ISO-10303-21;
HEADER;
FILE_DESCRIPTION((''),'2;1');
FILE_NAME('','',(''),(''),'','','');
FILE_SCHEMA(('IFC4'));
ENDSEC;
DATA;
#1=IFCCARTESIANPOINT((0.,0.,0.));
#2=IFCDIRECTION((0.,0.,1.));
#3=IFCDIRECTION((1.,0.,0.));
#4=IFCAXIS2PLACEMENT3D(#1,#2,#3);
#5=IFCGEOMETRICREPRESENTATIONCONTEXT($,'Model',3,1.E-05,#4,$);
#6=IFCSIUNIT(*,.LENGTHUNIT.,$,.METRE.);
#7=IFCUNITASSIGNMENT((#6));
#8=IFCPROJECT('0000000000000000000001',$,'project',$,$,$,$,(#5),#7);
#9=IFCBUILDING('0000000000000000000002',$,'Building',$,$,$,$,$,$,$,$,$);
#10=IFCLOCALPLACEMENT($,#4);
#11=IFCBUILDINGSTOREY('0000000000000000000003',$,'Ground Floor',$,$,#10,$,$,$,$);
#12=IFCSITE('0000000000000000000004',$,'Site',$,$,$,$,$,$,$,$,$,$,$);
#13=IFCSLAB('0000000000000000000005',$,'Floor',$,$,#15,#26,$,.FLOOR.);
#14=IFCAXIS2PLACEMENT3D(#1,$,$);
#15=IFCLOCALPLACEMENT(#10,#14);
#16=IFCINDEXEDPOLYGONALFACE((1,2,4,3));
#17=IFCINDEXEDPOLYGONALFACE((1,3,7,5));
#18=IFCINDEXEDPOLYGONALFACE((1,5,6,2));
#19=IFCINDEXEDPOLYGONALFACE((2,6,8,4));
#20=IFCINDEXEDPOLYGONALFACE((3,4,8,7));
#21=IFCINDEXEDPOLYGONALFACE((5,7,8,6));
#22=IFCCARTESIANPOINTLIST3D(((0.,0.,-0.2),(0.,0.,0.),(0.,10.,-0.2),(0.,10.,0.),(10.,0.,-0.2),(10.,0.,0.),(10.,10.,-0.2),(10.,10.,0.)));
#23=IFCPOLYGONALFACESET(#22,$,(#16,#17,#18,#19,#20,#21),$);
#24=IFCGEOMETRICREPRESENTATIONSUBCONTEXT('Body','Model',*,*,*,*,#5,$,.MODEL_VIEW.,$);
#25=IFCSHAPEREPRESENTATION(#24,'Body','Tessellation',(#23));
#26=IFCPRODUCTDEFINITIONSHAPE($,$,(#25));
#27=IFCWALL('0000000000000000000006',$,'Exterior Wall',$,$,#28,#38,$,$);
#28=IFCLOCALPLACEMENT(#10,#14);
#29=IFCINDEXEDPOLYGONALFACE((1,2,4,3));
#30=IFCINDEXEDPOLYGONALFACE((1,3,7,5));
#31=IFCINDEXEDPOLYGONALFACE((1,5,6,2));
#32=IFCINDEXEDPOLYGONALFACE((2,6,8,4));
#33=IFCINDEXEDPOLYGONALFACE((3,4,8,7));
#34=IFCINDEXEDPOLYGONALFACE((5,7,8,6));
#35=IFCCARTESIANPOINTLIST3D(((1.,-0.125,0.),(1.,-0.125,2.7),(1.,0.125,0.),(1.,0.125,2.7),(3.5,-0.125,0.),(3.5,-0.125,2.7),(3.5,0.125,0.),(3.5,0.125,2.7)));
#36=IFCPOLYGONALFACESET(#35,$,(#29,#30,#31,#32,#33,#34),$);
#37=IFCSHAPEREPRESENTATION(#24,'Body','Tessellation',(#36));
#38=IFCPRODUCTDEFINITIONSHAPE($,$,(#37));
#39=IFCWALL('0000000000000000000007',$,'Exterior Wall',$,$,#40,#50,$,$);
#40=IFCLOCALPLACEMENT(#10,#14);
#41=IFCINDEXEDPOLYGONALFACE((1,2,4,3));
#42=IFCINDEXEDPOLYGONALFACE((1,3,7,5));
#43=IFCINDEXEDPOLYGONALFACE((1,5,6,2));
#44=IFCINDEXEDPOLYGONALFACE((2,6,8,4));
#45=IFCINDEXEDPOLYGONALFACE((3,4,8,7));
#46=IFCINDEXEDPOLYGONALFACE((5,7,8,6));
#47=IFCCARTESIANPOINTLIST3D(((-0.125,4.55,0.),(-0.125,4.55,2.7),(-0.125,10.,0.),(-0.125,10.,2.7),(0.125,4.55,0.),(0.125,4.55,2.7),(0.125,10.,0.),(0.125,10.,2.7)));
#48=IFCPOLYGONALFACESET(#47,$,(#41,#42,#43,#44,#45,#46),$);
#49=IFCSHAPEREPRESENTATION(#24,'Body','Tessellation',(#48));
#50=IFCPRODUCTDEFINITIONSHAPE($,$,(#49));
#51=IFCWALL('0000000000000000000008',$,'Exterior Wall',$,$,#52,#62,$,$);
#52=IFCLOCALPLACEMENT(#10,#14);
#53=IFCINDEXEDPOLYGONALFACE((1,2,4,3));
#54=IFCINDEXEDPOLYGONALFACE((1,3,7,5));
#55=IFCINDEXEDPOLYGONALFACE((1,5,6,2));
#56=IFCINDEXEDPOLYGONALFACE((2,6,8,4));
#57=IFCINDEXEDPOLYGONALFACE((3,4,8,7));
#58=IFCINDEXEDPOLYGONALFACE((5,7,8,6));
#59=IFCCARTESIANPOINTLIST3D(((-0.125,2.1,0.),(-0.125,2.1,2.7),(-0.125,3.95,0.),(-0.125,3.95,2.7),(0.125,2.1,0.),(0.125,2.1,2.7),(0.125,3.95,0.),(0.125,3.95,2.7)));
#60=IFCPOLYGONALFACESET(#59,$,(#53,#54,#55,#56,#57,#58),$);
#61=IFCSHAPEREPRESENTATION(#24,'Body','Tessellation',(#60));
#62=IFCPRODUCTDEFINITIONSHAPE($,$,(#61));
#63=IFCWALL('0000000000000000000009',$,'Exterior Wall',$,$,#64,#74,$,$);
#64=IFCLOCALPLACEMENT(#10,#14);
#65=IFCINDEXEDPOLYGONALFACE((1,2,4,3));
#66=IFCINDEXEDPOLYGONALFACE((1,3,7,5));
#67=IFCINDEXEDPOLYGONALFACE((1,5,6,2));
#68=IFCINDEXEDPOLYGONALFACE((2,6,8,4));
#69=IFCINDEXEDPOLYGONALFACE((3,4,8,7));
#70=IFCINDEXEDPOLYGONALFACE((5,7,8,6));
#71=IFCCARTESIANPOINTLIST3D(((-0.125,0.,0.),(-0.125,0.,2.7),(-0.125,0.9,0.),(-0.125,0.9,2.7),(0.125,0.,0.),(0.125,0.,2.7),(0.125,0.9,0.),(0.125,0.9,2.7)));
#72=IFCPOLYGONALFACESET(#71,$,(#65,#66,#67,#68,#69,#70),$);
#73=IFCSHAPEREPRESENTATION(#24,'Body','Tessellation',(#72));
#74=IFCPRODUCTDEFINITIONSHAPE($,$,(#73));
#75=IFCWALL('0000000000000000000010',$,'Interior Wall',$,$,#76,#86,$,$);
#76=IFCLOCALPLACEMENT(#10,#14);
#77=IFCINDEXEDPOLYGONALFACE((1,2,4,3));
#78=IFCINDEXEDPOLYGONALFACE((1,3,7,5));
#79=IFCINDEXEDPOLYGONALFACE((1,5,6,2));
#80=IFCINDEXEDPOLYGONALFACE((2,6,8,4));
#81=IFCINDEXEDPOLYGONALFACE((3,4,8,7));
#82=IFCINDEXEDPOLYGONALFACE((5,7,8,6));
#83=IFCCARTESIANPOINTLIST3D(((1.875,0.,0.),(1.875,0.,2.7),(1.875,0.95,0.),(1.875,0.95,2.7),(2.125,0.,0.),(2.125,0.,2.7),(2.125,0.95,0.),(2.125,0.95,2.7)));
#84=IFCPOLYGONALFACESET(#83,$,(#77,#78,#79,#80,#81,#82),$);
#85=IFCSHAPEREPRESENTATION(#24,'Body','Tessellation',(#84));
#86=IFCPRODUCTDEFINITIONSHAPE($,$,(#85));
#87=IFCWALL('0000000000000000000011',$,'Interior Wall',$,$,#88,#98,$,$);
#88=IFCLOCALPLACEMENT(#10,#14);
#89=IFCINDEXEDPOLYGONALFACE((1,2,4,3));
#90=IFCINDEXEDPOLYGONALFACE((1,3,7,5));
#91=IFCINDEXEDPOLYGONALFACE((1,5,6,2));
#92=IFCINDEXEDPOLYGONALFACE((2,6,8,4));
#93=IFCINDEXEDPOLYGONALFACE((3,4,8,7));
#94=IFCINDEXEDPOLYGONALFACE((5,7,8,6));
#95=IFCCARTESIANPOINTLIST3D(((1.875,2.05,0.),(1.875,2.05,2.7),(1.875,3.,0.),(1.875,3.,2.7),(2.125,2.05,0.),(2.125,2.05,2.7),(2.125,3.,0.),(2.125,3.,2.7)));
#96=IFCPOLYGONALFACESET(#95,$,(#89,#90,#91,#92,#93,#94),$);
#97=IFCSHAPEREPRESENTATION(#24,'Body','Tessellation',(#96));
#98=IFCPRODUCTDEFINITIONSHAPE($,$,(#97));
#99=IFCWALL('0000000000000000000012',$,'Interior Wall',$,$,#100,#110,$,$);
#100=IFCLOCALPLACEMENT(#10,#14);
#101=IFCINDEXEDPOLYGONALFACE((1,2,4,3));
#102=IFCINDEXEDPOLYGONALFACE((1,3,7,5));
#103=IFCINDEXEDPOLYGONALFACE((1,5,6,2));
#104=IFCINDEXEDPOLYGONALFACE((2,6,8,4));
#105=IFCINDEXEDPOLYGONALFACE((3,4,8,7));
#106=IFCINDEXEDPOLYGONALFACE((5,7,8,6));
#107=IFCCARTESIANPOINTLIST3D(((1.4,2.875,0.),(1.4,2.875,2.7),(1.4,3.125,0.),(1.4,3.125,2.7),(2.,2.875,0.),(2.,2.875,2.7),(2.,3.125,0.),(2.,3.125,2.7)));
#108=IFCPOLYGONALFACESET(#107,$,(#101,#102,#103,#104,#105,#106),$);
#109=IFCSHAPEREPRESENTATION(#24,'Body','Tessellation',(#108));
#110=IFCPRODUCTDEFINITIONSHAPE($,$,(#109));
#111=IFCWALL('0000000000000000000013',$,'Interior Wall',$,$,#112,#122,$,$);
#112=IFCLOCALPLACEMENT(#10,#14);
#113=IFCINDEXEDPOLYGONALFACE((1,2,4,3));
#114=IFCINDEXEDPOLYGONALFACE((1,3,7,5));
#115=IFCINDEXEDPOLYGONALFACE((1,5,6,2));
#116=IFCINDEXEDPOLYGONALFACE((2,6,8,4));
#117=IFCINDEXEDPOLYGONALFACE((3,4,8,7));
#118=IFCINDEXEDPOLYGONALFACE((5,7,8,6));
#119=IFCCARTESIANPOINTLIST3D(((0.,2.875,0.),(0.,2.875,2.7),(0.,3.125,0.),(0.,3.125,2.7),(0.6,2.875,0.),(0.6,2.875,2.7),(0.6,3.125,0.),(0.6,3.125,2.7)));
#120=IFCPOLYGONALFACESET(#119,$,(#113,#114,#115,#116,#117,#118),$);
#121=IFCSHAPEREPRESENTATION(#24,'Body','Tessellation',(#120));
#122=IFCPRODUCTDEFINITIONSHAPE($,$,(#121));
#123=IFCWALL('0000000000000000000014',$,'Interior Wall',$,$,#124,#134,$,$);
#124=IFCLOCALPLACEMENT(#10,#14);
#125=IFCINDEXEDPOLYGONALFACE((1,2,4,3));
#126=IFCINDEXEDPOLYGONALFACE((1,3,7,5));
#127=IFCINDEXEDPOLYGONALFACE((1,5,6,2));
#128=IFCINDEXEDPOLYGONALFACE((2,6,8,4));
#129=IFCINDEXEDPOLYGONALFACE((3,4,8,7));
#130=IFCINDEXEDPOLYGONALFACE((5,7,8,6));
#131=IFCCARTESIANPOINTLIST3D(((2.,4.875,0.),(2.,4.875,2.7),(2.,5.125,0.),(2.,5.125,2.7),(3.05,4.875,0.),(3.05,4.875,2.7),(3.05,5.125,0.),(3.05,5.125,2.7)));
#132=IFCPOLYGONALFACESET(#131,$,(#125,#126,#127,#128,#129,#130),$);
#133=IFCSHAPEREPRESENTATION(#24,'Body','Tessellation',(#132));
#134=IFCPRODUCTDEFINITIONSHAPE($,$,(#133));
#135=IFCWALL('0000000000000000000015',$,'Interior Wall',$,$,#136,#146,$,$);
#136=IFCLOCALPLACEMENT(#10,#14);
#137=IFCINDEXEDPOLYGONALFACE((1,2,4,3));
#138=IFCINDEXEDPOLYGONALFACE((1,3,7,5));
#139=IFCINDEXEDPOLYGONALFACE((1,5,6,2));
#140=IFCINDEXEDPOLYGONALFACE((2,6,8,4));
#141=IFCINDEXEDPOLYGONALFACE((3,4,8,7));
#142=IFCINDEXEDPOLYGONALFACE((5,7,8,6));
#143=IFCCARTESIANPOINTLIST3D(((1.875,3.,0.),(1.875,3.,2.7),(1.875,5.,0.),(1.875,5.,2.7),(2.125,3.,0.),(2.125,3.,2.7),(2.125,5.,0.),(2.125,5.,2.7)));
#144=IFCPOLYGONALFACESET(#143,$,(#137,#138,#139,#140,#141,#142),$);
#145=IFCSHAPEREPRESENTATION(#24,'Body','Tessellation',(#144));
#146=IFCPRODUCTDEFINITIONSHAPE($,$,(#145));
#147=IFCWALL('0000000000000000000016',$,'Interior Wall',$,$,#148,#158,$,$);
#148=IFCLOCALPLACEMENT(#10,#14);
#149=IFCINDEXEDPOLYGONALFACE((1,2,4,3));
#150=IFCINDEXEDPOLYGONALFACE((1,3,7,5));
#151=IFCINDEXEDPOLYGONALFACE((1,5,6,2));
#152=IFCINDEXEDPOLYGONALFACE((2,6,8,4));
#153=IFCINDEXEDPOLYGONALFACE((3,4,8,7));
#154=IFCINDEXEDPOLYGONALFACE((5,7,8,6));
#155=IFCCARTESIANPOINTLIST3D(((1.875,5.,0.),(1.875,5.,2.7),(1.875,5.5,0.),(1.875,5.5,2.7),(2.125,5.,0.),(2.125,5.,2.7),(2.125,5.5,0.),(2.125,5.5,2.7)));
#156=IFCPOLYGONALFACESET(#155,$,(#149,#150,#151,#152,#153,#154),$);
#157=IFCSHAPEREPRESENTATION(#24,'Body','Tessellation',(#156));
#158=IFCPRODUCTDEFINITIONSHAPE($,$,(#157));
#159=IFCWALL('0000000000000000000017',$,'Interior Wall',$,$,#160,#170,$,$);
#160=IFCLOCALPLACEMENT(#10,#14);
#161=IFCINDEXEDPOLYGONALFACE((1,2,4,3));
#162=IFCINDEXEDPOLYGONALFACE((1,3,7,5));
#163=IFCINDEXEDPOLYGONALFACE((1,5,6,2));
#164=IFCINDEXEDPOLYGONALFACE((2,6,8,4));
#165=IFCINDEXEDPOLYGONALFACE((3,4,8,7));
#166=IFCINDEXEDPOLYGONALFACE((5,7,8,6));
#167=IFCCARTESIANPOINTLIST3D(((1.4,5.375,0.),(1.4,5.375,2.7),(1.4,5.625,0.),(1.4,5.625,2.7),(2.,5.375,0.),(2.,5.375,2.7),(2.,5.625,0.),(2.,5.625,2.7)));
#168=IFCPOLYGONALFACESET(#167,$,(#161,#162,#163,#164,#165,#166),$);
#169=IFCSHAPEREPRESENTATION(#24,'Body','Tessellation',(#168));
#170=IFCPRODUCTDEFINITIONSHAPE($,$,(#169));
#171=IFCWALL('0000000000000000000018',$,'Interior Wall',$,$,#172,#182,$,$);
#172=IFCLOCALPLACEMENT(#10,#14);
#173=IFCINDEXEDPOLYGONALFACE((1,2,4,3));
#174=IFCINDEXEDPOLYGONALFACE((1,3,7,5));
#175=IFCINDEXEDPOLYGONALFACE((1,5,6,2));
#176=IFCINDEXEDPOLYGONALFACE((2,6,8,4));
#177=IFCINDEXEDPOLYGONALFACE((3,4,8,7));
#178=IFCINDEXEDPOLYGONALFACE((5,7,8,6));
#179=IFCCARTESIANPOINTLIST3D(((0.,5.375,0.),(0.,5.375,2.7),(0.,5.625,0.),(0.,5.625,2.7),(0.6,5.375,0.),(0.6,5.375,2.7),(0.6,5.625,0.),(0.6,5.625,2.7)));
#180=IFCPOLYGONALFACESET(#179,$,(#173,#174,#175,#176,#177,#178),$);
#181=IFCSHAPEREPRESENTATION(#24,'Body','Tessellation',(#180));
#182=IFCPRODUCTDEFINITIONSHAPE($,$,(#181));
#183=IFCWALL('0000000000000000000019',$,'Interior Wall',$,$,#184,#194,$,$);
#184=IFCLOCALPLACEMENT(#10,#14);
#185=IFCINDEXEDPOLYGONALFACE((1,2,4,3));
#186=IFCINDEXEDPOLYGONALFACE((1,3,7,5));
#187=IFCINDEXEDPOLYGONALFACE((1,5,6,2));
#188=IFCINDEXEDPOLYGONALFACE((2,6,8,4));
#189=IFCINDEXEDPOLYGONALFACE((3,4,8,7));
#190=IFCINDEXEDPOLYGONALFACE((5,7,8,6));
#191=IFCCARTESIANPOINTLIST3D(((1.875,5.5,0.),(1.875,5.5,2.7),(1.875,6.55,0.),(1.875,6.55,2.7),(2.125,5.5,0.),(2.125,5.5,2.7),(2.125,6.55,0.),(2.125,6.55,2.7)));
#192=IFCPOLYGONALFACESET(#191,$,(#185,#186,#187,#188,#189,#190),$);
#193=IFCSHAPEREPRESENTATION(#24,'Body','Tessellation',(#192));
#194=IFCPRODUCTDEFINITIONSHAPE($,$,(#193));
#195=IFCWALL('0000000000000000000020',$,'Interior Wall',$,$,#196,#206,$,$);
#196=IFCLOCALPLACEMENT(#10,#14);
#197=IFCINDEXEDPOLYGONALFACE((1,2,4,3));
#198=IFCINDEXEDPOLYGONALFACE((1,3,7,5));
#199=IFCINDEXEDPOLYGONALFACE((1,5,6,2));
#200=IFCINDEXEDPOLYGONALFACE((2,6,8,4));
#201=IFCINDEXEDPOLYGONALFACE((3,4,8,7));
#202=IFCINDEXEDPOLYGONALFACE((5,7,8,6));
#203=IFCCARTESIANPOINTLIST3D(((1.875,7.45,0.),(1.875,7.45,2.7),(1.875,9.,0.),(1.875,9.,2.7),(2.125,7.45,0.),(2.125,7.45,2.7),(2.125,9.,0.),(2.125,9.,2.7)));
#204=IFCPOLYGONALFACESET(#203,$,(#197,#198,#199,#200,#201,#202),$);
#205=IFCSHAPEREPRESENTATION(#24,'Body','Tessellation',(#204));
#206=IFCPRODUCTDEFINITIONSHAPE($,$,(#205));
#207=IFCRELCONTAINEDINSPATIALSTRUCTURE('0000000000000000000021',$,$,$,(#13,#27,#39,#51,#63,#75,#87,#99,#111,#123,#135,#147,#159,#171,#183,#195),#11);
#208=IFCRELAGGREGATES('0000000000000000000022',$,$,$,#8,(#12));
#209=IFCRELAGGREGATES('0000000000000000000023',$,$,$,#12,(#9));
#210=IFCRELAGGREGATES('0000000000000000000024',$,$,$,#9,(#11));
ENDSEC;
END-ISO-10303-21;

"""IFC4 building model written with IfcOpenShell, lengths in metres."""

from ifc_helpers import new_model, si_unit, frame, origin_with_axes, place, context, subcontext, project, spatial, indexed_curve, outline, extrude, element, save


model = new_model("IFC4")

# Units and contexts
model_context = context("Model", 3, precision=1e-05, world=origin_with_axes())
body_context = subcontext(model_context, "Body", "Model", "MODEL_VIEW")
ifc_project = project(units=[si_unit("LENGTHUNIT", "METRE")], contexts=[model_context])

# Site, building, storey
site = spatial("IfcSite", under=ifc_project, Name="Site")
building = spatial("IfcBuilding", under=site, Name="Building")
storey_placement = place(None, origin_with_axes())
storey = spatial("IfcBuildingStorey", under=building, at=storey_placement, Name="Ground Floor")

# Slab
slab_placement = place(storey_placement, frame((0.0, 0.0, -0.2), z_axis=(0.0, 0.0, 1.0), x_axis=(1.0, 0.0, 0.0)))
element("IfcSlab", 1, at=slab_placement, inside=storey, Name="Floor", PredefinedType="FLOOR", context=body_context, shape_type="SweptSolid", body=[
    extrude(outline(indexed_curve([(0.0, 0.0), (10.0, 0.0), (10.0, 10.0), (0.0, 10.0)])), None, (0.0, 0.0, 1.0), 0.2),
])

# Walls
wall_1_placement = place(storey_placement, frame((1.0, 0.0, 0.0), z_axis=(0.0, 0.0, 1.0), x_axis=(1.0, 0.0, 0.0)))
element("IfcWall", 2, at=wall_1_placement, inside=storey, Name="Exterior Wall", context=body_context, shape_type="SweptSolid", body=[
    extrude(outline(indexed_curve([(0.0, 0.0), (0.0, 0.25), (2.5, 0.25), (2.5, 0.0), (0.0, 0.0)], self_intersect=False)), frame((0.0, -0.125, 0.0), z_axis=(0.0, 0.0, 1.0), x_axis=(1.0, 0.0, 0.0)), (0.0, 0.0, 1.0), 2.7),
])
wall_2_placement = place(storey_placement, frame((0.0, 10.0, 0.0), z_axis=(0.0, 0.0, 1.0), x_axis=(0.0, -1.0, 0.0)))
element("IfcWall", 3, at=wall_2_placement, inside=storey, Name="Exterior Wall", context=body_context, shape_type="SweptSolid", body=[
    extrude(outline(indexed_curve([(0.0, 0.0), (0.0, 0.25), (5.45, 0.25), (5.45, 0.0), (0.0, 0.0)], self_intersect=False)), frame((0.0, -0.125, 0.0), z_axis=(0.0, 0.0, 1.0), x_axis=(1.0, 0.0, 0.0)), (0.0, 0.0, 1.0), 2.7),
])
wall_3_placement = place(storey_placement, frame((0.0, 3.95, 0.0), z_axis=(0.0, 0.0, 1.0), x_axis=(0.0, -1.0, 0.0)))
element("IfcWall", 4, at=wall_3_placement, inside=storey, Name="Exterior Wall", context=body_context, shape_type="SweptSolid", body=[
    extrude(outline(indexed_curve([(0.0, 0.0), (0.0, 0.25), (1.85, 0.25), (1.85, 0.0), (0.0, 0.0)], self_intersect=False)), frame((0.0, -0.125, 0.0), z_axis=(0.0, 0.0, 1.0), x_axis=(1.0, 0.0, 0.0)), (0.0, 0.0, 1.0), 2.7),
])
wall_4_placement = place(storey_placement, frame((0.0, 0.9, 0.0), z_axis=(0.0, 0.0, 1.0), x_axis=(0.0, -1.0, 0.0)))
element("IfcWall", 5, at=wall_4_placement, inside=storey, Name="Exterior Wall", context=body_context, shape_type="SweptSolid", body=[
    extrude(outline(indexed_curve([(0.0, 0.0), (0.0, 0.25), (0.9, 0.25), (0.9, 0.0), (0.0, 0.0)], self_intersect=False)), frame((0.0, -0.125, 0.0), z_axis=(0.0, 0.0, 1.0), x_axis=(1.0, 0.0, 0.0)), (0.0, 0.0, 1.0), 2.7),
])
wall_5_placement = place(storey_placement, frame((2.0, 0.0, 0.0), z_axis=(0.0, 0.0, 1.0), x_axis=(0.0, 1.0, 0.0)))
element("IfcWall", 6, at=wall_5_placement, inside=storey, Name="Interior Wall", context=body_context, shape_type="SweptSolid", body=[
    extrude(outline(indexed_curve([(0.0, 0.0), (0.0, 0.25), (0.95, 0.25), (0.95, 0.0), (0.0, 0.0)], self_intersect=False)), frame((0.0, -0.125, 0.0), z_axis=(0.0, 0.0, 1.0), x_axis=(1.0, 0.0, 0.0)), (0.0, 0.0, 1.0), 2.7),
])
wall_6_placement = place(storey_placement, frame((2.0, 2.05, 0.0), z_axis=(0.0, 0.0, 1.0), x_axis=(0.0, 1.0, 0.0)))
element("IfcWall", 7, at=wall_6_placement, inside=storey, Name="Interior Wall", context=body_context, shape_type="SweptSolid", body=[
    extrude(outline(indexed_curve([(0.0, 0.0), (0.0, 0.25), (0.95, 0.25), (0.95, 0.0), (0.0, 0.0)], self_intersect=False)), frame((0.0, -0.125, 0.0), z_axis=(0.0, 0.0, 1.0), x_axis=(1.0, 0.0, 0.0)), (0.0, 0.0, 1.0), 2.7),
])
for number, where, z_axis, x_axis, name in (
    (8, (2.0, 3.0, 0.0), (0.0, 0.0, 1.0), (-1.0, 0.0, 0.0), "Interior Wall"),
    (9, (0.6, 3.0, 0.0), (0.0, 0.0, 1.0), (-1.0, 0.0, 0.0), "Interior Wall"),
):
    element("IfcWall", number, at=place(storey_placement, frame(where, z_axis=z_axis, x_axis=x_axis)), inside=storey, Name=name, context=body_context, shape_type="SweptSolid", body=[
        extrude(outline(indexed_curve([(0.0, 0.0), (0.0, 0.25), (0.6, 0.25), (0.6, 0.0), (0.0, 0.0)], self_intersect=False)), frame((0.0, -0.125, 0.0), z_axis=(0.0, 0.0, 1.0), x_axis=(1.0, 0.0, 0.0)), (0.0, 0.0, 1.0), 2.7),
    ])
wall_7_placement = place(storey_placement, frame((3.05, 5.0, 0.0), z_axis=(0.0, 0.0, 1.0), x_axis=(-1.0, 0.0, 0.0)))
element("IfcWall", 10, at=wall_7_placement, inside=storey, Name="Interior Wall", context=body_context, shape_type="SweptSolid", body=[
    extrude(outline(indexed_curve([(0.0, 0.0), (0.0, 0.25), (1.05, 0.25), (1.05, 0.0), (0.0, 0.0)], self_intersect=False)), frame((0.0, -0.125, 0.0), z_axis=(0.0, 0.0, 1.0), x_axis=(1.0, 0.0, 0.0)), (0.0, 0.0, 1.0), 2.7),
])
wall_8_placement = place(storey_placement, frame((2.0, 5.0, 0.0), z_axis=(0.0, 0.0, 1.0), x_axis=(0.0, -1.0, 0.0)))
element("IfcWall", 11, at=wall_8_placement, inside=storey, Name="Interior Wall", context=body_context, shape_type="SweptSolid", body=[
    extrude(outline(indexed_curve([(0.0, 0.0), (0.0, 0.25), (2.0, 0.25), (2.0, 0.0), (0.0, 0.0)], self_intersect=False)), frame((0.0, -0.125, 0.0), z_axis=(0.0, 0.0, 1.0), x_axis=(1.0, 0.0, 0.0)), (0.0, 0.0, 1.0), 2.7),
])
wall_9_placement = place(storey_placement, frame((2.0, 5.0, 0.0), z_axis=(0.0, 0.0, 1.0), x_axis=(0.0, 1.0, 0.0)))
element("IfcWall", 12, at=wall_9_placement, inside=storey, Name="Interior Wall", context=body_context, shape_type="SweptSolid", body=[
    extrude(outline(indexed_curve([(0.0, 0.0), (0.0, 0.25), (0.5, 0.25), (0.5, 0.0), (0.0, 0.0)], self_intersect=False)), frame((0.0, -0.125, 0.0), z_axis=(0.0, 0.0, 1.0), x_axis=(1.0, 0.0, 0.0)), (0.0, 0.0, 1.0), 2.7),
])
for number, where, z_axis, x_axis, name in (
    (13, (2.0, 5.5, 0.0), (0.0, 0.0, 1.0), (-1.0, 0.0, 0.0), "Interior Wall"),
    (14, (0.6, 5.5, 0.0), (0.0, 0.0, 1.0), (-1.0, 0.0, 0.0), "Interior Wall"),
):
    element("IfcWall", number, at=place(storey_placement, frame(where, z_axis=z_axis, x_axis=x_axis)), inside=storey, Name=name, context=body_context, shape_type="SweptSolid", body=[
        extrude(outline(indexed_curve([(0.0, 0.0), (0.0, 0.25), (0.6, 0.25), (0.6, 0.0), (0.0, 0.0)], self_intersect=False)), frame((0.0, -0.125, 0.0), z_axis=(0.0, 0.0, 1.0), x_axis=(1.0, 0.0, 0.0)), (0.0, 0.0, 1.0), 2.7),
    ])
wall_10_placement = place(storey_placement, frame((2.0, 5.5, 0.0), z_axis=(0.0, 0.0, 1.0), x_axis=(0.0, 1.0, 0.0)))
element("IfcWall", 15, at=wall_10_placement, inside=storey, Name="Interior Wall", context=body_context, shape_type="SweptSolid", body=[
    extrude(outline(indexed_curve([(0.0, 0.0), (0.0, 0.25), (1.05, 0.25), (1.05, 0.0), (0.0, 0.0)], self_intersect=False)), frame((0.0, -0.125, 0.0), z_axis=(0.0, 0.0, 1.0), x_axis=(1.0, 0.0, 0.0)), (0.0, 0.0, 1.0), 2.7),
])
wall_11_placement = place(storey_placement, frame((2.0, 7.45, 0.0), z_axis=(0.0, 0.0, 1.0), x_axis=(0.0, 1.0, 0.0)))
element("IfcWall", 16, at=wall_11_placement, inside=storey, Name="Interior Wall", context=body_context, shape_type="SweptSolid", body=[
    extrude(outline(indexed_curve([(0.0, 0.0), (0.0, 0.25), (1.55, 0.25), (1.55, 0.0), (0.0, 0.0)], self_intersect=False)), frame((0.0, -0.125, 0.0), z_axis=(0.0, 0.0, 1.0), x_axis=(1.0, 0.0, 0.0)), (0.0, 0.0, 1.0), 2.7),
])

save(model, "model.ifc")
